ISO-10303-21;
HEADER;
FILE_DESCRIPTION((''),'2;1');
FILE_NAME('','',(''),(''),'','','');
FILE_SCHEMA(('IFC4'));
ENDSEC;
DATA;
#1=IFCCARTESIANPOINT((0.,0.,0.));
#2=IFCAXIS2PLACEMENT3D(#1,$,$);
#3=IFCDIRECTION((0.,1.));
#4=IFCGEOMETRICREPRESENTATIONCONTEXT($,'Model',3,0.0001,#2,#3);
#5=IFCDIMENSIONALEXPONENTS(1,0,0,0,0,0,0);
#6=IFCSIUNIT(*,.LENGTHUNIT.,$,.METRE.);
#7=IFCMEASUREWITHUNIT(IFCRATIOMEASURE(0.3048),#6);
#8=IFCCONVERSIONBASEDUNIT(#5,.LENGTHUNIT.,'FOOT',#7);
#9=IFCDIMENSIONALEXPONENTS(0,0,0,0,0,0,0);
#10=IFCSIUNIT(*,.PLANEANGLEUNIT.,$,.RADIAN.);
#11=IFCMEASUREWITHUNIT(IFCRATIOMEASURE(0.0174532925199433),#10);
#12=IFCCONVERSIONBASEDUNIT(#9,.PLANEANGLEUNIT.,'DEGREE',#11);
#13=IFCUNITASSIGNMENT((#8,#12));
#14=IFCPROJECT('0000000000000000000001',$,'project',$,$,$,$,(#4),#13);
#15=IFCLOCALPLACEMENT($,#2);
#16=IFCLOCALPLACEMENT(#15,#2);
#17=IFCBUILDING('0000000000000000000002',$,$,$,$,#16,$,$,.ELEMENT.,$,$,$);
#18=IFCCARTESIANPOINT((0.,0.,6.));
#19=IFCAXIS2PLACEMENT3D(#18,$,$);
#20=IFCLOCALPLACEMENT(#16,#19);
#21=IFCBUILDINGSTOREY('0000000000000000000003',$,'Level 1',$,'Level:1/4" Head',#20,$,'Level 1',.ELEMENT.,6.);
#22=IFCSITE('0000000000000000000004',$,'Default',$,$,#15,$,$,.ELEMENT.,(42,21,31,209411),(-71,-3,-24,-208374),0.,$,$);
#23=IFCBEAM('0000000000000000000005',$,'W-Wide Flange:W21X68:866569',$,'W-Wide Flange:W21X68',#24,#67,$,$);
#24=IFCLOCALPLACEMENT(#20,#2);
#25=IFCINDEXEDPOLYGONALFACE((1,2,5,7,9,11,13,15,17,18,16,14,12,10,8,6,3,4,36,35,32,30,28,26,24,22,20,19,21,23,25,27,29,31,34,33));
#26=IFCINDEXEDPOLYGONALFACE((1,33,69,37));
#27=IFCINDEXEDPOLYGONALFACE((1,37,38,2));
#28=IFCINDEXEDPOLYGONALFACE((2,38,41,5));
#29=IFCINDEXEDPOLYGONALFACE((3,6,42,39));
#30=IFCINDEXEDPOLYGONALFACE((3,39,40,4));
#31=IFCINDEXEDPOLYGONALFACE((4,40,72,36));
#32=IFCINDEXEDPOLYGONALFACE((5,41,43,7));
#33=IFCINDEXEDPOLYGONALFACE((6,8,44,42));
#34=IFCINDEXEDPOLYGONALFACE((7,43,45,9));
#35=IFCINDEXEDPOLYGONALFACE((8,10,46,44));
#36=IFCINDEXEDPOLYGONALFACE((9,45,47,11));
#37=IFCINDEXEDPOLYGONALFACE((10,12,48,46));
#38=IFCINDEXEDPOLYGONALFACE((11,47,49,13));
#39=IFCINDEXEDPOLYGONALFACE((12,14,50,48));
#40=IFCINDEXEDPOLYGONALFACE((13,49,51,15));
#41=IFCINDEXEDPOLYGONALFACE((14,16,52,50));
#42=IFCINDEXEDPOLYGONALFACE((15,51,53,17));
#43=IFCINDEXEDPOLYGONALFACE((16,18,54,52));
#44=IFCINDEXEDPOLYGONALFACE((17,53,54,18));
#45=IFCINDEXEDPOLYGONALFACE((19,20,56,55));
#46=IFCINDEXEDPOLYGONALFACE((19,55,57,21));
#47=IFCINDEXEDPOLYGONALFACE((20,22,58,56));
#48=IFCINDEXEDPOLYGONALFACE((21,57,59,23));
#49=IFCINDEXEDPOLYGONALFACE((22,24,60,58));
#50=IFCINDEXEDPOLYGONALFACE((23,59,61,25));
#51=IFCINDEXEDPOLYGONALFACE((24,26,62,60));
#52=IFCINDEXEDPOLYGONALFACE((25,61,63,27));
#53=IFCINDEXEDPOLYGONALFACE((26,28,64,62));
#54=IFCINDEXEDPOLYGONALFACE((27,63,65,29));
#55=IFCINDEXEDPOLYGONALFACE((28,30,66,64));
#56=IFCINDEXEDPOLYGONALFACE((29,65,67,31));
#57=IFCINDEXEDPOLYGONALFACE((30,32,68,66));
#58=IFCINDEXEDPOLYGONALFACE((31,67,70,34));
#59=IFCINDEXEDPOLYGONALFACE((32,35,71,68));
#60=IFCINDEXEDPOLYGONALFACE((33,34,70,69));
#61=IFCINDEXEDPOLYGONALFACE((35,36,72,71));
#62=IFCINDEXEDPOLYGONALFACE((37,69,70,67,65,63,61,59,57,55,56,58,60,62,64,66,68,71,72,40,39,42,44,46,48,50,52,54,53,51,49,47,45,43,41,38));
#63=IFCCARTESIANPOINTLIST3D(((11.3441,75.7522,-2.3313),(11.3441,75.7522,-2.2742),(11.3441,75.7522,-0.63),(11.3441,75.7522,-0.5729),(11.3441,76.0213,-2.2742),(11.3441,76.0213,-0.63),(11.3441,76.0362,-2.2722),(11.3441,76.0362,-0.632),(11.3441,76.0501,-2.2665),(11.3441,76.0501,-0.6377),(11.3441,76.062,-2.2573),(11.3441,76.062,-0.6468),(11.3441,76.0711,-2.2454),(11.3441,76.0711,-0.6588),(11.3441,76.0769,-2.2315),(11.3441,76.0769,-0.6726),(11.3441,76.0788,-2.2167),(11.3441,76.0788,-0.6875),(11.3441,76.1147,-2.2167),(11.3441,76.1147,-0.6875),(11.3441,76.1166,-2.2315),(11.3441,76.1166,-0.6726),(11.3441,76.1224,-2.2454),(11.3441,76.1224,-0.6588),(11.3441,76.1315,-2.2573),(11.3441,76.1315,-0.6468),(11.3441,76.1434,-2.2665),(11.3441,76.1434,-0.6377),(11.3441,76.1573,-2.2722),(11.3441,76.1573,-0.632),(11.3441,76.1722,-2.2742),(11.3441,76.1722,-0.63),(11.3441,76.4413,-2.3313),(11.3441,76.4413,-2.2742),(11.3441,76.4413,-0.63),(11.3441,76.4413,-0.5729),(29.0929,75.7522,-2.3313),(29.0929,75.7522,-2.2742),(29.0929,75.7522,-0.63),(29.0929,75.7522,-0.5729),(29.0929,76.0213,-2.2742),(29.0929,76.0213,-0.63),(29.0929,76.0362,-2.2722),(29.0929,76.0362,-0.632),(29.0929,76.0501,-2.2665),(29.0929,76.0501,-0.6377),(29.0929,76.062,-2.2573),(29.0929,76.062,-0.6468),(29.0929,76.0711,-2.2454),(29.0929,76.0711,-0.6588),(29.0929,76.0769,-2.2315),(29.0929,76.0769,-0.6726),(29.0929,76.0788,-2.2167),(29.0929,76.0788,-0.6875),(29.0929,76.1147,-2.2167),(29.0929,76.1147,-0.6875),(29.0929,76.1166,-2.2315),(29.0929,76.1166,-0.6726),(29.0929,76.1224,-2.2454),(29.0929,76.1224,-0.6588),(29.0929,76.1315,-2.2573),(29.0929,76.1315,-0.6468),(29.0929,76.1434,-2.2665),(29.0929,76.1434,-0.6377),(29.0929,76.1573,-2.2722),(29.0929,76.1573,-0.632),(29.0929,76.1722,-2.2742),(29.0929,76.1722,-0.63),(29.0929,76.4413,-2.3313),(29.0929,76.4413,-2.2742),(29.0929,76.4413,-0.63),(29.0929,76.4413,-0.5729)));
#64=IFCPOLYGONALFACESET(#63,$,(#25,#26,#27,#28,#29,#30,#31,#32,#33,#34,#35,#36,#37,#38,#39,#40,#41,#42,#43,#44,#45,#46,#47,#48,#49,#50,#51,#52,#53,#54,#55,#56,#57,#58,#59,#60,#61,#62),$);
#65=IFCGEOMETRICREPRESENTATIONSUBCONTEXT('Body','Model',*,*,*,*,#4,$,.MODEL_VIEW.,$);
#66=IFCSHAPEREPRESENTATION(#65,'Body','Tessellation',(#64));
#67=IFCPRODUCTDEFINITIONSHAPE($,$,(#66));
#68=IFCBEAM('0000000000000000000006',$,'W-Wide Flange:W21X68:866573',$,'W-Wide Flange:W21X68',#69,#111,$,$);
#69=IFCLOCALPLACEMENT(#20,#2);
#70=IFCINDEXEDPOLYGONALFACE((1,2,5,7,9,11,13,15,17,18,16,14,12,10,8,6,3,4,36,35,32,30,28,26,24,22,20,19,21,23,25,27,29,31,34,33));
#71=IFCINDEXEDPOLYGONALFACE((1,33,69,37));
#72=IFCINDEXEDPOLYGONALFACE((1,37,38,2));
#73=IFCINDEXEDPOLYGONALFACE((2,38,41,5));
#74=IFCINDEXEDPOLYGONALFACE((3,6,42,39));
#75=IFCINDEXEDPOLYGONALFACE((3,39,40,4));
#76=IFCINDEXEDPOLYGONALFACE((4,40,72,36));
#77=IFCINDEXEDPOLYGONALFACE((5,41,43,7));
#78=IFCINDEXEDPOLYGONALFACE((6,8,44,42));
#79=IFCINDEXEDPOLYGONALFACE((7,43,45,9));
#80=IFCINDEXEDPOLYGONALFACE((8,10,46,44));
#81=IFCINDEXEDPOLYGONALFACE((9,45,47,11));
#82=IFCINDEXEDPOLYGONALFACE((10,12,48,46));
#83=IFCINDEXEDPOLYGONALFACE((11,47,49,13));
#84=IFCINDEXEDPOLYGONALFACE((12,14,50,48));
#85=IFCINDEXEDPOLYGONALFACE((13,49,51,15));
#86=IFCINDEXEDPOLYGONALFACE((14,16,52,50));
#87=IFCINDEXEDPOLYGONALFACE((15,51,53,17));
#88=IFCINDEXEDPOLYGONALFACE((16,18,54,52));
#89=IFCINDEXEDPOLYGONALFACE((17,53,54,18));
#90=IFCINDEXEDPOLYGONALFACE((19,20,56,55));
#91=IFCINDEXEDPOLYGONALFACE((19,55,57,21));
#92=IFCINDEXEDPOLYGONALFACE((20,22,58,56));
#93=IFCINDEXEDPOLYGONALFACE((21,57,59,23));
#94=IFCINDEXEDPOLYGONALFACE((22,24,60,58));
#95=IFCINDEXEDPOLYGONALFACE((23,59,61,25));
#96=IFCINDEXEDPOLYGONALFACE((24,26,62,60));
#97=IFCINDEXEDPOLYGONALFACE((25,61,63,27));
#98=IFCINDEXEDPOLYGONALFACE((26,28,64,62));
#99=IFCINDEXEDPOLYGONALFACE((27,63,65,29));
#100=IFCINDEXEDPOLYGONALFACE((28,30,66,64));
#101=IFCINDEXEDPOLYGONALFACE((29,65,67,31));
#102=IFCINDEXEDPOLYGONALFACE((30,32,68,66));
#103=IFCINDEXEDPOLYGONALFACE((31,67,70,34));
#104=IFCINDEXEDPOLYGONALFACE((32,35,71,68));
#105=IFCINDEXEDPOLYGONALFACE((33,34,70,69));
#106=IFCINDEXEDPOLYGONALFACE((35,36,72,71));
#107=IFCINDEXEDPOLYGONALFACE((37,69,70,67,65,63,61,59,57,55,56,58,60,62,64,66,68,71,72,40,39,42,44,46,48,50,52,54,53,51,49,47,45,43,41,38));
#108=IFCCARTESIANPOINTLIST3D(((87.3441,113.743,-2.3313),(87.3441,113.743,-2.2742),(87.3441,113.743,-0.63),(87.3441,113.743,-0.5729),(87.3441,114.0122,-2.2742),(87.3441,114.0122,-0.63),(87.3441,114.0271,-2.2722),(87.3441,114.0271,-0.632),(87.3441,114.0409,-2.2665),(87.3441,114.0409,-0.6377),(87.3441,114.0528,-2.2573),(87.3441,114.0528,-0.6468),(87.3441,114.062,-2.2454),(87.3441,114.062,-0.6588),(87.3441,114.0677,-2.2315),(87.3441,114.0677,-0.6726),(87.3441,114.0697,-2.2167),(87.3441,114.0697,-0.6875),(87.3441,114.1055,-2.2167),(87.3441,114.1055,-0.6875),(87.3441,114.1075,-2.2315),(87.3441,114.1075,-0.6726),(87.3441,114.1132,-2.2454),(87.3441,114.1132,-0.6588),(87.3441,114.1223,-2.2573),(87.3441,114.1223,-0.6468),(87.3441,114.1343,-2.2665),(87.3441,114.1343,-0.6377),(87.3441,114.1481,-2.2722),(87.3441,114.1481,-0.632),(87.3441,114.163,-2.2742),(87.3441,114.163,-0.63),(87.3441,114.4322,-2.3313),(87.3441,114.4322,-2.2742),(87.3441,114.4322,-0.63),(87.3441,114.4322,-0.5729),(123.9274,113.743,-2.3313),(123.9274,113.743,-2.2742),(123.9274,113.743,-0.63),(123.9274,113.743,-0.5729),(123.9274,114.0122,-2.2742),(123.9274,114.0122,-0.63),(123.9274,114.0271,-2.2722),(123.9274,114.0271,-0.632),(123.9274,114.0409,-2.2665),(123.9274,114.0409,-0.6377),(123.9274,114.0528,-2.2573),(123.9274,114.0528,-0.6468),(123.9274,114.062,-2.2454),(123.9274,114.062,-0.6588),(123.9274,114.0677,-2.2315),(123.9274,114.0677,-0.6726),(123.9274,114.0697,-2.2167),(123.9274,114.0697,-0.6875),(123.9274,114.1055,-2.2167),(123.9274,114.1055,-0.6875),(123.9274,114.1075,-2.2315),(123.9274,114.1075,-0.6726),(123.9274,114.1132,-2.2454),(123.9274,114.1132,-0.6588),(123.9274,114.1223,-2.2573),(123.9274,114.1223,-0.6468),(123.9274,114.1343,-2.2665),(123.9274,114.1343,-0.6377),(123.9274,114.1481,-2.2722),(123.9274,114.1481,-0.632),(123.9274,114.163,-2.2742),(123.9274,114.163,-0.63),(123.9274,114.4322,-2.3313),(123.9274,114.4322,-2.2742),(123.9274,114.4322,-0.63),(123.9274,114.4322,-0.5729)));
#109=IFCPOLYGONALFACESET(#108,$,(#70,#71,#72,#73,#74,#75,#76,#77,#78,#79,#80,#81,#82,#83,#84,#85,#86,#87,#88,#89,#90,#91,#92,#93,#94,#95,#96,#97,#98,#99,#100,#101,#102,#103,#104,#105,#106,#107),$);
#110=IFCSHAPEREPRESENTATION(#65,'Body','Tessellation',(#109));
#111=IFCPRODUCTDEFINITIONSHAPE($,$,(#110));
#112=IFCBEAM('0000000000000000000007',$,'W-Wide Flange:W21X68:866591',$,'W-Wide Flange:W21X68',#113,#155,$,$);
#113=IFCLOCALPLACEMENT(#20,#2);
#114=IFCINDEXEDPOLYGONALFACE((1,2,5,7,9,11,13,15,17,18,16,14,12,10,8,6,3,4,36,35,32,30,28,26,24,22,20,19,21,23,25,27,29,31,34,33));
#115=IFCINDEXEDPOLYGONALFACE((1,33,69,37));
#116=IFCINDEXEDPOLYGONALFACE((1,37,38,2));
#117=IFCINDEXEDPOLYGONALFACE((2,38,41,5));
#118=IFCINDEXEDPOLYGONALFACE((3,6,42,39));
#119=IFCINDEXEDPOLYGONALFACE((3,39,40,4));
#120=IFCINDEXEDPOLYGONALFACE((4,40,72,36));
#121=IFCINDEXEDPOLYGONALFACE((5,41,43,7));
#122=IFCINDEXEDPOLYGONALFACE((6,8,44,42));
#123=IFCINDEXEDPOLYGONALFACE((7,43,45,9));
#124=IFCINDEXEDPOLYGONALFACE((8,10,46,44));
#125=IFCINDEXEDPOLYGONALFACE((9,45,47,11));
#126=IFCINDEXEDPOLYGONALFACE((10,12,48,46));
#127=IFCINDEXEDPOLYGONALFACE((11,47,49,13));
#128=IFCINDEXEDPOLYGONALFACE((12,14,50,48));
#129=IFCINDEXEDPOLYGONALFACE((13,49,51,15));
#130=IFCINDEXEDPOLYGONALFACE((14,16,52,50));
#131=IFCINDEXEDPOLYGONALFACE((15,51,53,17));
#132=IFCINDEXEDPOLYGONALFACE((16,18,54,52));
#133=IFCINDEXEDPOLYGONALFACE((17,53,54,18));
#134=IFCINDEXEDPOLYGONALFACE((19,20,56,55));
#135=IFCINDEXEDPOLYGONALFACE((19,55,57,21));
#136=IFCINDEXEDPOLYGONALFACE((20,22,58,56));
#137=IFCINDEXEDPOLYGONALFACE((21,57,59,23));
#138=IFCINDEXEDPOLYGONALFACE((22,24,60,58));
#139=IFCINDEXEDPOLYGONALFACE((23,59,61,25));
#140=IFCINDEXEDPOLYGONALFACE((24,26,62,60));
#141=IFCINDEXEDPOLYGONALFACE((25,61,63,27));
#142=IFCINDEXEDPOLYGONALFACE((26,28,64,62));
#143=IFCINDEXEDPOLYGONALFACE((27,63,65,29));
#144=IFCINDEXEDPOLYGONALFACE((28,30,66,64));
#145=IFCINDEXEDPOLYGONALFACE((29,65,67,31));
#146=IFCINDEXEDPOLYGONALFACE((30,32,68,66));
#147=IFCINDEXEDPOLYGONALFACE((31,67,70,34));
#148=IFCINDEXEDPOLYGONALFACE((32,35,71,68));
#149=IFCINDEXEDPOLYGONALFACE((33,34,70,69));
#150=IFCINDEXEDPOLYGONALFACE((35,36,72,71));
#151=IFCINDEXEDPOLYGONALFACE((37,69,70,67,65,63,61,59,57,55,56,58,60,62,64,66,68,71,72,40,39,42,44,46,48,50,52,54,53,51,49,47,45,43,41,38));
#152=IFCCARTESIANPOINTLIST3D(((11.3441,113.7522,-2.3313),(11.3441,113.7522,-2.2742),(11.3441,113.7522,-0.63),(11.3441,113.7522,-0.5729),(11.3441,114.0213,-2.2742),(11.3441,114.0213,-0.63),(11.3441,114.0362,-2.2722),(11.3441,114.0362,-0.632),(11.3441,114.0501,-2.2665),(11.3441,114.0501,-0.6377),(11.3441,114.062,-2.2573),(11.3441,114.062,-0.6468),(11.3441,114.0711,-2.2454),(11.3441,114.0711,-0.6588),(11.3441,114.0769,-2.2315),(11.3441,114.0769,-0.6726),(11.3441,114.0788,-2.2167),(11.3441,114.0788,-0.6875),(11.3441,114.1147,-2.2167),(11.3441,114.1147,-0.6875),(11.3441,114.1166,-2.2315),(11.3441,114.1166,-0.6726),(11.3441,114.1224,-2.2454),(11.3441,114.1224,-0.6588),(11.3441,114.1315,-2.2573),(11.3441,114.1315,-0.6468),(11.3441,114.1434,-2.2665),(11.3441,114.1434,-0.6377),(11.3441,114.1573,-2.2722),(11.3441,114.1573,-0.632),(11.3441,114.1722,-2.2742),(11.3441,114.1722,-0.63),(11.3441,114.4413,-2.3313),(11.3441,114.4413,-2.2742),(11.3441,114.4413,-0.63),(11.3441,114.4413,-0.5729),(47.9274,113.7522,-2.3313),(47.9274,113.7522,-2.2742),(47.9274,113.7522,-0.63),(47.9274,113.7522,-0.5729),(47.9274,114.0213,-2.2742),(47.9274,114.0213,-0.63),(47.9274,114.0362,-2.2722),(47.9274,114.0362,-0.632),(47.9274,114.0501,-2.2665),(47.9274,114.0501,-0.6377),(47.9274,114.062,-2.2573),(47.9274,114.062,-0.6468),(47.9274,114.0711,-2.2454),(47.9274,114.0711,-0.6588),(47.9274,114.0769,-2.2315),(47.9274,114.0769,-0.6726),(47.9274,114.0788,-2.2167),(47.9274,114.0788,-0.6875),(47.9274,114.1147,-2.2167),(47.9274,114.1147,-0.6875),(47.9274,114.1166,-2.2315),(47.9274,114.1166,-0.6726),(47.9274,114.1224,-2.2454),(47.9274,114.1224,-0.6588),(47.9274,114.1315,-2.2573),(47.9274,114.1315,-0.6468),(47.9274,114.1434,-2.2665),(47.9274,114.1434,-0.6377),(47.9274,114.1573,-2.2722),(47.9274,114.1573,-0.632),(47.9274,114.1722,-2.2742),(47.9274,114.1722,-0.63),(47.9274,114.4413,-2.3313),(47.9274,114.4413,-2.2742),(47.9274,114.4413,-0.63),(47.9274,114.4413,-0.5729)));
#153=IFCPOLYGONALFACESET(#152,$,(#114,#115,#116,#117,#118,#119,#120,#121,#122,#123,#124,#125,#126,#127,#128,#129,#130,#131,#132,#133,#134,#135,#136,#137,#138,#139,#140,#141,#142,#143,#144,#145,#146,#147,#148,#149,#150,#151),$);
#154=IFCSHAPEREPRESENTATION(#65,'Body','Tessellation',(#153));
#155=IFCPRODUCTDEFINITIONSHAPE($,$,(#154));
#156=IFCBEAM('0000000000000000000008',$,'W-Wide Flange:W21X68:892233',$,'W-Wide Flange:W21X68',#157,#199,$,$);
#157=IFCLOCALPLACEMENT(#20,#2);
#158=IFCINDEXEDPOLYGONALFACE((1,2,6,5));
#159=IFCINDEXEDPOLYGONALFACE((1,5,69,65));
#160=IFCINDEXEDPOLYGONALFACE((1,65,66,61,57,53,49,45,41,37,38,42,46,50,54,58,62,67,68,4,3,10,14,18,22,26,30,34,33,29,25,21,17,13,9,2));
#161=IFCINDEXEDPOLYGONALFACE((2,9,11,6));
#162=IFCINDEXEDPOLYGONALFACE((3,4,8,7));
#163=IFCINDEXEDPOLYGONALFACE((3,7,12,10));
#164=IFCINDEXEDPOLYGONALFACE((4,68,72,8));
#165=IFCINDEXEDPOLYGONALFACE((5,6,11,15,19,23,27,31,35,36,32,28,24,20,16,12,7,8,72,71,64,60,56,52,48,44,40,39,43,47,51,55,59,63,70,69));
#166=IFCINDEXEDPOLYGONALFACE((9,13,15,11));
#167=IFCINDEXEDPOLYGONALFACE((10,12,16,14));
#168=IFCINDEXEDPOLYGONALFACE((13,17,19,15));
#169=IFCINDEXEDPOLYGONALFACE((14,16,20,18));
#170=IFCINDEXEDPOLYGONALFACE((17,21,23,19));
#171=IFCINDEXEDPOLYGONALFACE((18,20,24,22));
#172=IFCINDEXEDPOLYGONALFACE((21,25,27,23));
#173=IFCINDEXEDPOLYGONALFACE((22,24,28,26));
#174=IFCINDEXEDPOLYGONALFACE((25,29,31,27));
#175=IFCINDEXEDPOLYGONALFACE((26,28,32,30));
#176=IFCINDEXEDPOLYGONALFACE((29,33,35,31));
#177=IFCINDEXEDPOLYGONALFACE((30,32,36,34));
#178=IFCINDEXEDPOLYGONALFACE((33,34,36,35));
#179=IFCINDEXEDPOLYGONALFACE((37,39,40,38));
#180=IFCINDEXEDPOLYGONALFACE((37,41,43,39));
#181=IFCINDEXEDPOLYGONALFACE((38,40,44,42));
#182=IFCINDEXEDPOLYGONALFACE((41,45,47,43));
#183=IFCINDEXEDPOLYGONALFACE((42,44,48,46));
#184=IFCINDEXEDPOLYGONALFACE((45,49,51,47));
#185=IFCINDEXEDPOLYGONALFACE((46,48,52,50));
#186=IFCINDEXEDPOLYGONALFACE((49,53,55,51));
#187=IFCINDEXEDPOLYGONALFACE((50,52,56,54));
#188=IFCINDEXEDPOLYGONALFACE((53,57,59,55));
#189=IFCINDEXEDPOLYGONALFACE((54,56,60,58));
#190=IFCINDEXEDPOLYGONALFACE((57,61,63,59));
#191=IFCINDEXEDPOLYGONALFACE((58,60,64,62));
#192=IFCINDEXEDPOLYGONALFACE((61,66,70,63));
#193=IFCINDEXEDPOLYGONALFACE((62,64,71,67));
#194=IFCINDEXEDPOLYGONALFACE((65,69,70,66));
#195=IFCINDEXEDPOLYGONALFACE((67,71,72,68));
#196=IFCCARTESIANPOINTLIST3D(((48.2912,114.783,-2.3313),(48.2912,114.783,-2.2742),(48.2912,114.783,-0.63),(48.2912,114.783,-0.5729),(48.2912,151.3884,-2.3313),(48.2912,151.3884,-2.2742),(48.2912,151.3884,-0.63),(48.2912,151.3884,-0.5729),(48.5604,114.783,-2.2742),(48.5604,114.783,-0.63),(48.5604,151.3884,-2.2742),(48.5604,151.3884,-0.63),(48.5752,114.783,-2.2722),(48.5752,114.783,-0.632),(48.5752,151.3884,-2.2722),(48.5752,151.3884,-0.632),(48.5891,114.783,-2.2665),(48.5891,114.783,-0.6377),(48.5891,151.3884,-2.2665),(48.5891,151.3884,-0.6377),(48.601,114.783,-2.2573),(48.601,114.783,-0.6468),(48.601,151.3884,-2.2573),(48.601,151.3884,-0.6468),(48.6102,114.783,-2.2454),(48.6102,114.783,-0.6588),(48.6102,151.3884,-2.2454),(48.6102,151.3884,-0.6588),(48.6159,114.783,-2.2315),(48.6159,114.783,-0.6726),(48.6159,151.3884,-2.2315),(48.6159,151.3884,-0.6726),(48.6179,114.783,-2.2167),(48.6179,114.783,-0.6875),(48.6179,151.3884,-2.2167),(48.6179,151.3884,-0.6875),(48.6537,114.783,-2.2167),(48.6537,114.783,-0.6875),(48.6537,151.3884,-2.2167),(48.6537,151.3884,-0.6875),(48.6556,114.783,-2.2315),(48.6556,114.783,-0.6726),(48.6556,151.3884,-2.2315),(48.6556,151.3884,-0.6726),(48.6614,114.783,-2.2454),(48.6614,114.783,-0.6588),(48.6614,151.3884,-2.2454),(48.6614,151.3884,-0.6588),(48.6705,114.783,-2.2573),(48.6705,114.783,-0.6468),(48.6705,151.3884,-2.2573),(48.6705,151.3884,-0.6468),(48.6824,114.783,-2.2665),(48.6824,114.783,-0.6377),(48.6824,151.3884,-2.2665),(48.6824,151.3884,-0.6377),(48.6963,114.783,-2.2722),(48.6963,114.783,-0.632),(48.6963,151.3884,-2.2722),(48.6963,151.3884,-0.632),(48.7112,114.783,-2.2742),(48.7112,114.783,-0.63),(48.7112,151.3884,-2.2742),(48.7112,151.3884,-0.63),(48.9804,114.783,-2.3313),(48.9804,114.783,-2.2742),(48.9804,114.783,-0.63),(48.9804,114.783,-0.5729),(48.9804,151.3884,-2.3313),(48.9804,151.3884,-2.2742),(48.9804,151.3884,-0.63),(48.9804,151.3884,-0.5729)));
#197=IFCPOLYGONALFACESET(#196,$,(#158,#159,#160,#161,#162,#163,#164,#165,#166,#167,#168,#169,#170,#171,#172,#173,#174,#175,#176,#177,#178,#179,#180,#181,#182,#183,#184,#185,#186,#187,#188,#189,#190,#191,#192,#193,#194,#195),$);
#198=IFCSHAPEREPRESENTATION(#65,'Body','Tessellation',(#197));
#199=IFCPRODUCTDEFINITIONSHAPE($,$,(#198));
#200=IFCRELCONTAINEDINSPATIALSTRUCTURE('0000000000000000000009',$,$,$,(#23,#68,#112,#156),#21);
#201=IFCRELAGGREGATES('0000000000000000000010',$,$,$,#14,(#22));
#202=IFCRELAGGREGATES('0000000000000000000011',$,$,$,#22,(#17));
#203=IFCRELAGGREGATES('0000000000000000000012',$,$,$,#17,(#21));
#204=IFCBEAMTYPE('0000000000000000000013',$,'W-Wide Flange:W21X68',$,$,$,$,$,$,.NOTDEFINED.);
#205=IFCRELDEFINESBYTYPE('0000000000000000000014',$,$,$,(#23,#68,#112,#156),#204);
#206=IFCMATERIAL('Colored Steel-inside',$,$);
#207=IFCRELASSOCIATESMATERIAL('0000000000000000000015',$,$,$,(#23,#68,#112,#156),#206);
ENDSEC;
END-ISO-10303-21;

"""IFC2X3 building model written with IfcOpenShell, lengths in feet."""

from ifc_helpers import new_model, entity, si_unit, converted_unit, direction, frame, frame_2d, origin, place, context, subcontext, project, spatial, i_section, extrude, material, type_object, element, save


model = new_model("IFC2X3")

# Units and contexts
model_context = context("Model", 3, precision=0.0001, world=origin(), true_north=direction((0.0, 1.0)))
body_context = subcontext(model_context, "Body", "Model", "MODEL_VIEW")
ifc_project = project(units=[converted_unit("LENGTHUNIT", "FOOT", entity("IfcRatioMeasure", 0.3048), si_unit("LENGTHUNIT", "METRE"), dimensions=[1, 0, 0, 0, 0, 0, 0]), converted_unit("PLANEANGLEUNIT", "DEGREE", entity("IfcRatioMeasure", 0.0174532925199433), si_unit("PLANEANGLEUNIT", "RADIAN"), dimensions=[0, 0, 0, 0, 0, 0, 0])], contexts=[model_context])

# Site, building, storey
site_placement = place(None, origin())
site = spatial("IfcSite", under=ifc_project, at=site_placement, Name="Default", CompositionType="ELEMENT", RefLatitude=(42, 21, 31, 209411), RefLongitude=(-71, -3, -24, -208374), RefElevation=0.0)
building_placement = place(site_placement, origin())
building = spatial("IfcBuilding", under=site, at=building_placement, CompositionType="ELEMENT")
storey_placement = place(building_placement, frame((0.0, 0.0, 6.0)))
storey = spatial("IfcBuildingStorey", under=building, at=storey_placement, Name="Level 1", ObjectType="Level:1/4\" Head", LongName="Level 1", CompositionType="ELEMENT", Elevation=6.0)

# Shared definitions
ifc_material_1 = material(Name="Colored Steel-inside")

# Beams
beam_type_1 = type_object("IfcBeamType", Name="W-Wide Flange:W21X68", PredefinedType="NOTDEFINED")
beam_1_placement = place(storey_placement, frame((29.6345, 76.0968, 0.0), z_axis=(0.0, 0.0, 1.0), x_axis=(-1.0, 0.0, 0.0)))
element("IfcBeam", 1, at=beam_1_placement, inside=storey, type_object=beam_type_1, material=ifc_material_1, Name="W-Wide Flange:W21X68:866569", ObjectType="W-Wide Flange:W21X68", context=body_context, shape_type="SweptSolid", body=[
    extrude(i_section(OverallWidth=0.6892, OverallDepth=1.7583, WebThickness=0.0358, FlangeThickness=0.0571, FilletRadius=0.0575, at=frame_2d((0.0, 0.0), x_axis=(0.0, 1.0))), frame((0.5417, 0.0, -1.4521), z_axis=(1.0, 0.0, 0.0), x_axis=(0.0, 0.0, -1.0)), (0.0, 0.0, 1.0), 17.7487),
])
beam_2_placement = place(storey_placement, frame((124.6358, 114.0876, 0.0), z_axis=(0.0, 0.0, 1.0), x_axis=(-1.0, 0.0, 0.0)))
element("IfcBeam", 2, at=beam_2_placement, inside=storey, type_object=beam_type_1, material=ifc_material_1, Name="W-Wide Flange:W21X68:866573", ObjectType="W-Wide Flange:W21X68", context=body_context, shape_type="SweptSolid", body=[
    extrude(i_section(OverallWidth=0.6892, OverallDepth=1.7583, WebThickness=0.0358, FlangeThickness=0.0571, FilletRadius=0.0575, at=frame_2d((0.0, 0.0), x_axis=(0.0, 1.0))), frame((0.7083, 0.0, -1.4521), z_axis=(1.0, 0.0, 0.0), x_axis=(0.0, 0.0, -1.0)), (0.0, 0.0, 1.0), 36.5833),
])
beam_3_placement = place(storey_placement, frame((10.6358, 114.0968, 0.0)))
element("IfcBeam", 3, at=beam_3_placement, inside=storey, type_object=beam_type_1, material=ifc_material_1, Name="W-Wide Flange:W21X68:866591", ObjectType="W-Wide Flange:W21X68", context=body_context, shape_type="SweptSolid", body=[
    extrude(i_section(OverallWidth=0.6892, OverallDepth=1.7583, WebThickness=0.0358, FlangeThickness=0.0571, FilletRadius=0.0575, at=frame_2d((0.0, 0.0), x_axis=(0.0, 1.0))), frame((0.7083, 0.0, -1.4521), z_axis=(1.0, 0.0, 0.0), x_axis=(0.0, 0.0, -1.0)), (0.0, 0.0, 1.0), 36.5833),
])
beam_4_placement = place(storey_placement, frame((48.6358, 152.0968, 0.0), z_axis=(0.0, 0.0, 1.0), x_axis=(0.0, -1.0, 0.0)))
element("IfcBeam", 4, at=beam_4_placement, inside=storey, type_object=beam_type_1, material=ifc_material_1, Name="W-Wide Flange:W21X68:892233", ObjectType="W-Wide Flange:W21X68", context=body_context, shape_type="SweptSolid", body=[
    extrude(i_section(OverallWidth=0.6892, OverallDepth=1.7583, WebThickness=0.0358, FlangeThickness=0.0571, FilletRadius=0.0575, at=frame_2d((0.0, 0.0), x_axis=(0.0, 1.0))), frame((0.7083, 0.0, -1.4521), z_axis=(1.0, 0.0, 0.0), x_axis=(0.0, 0.0, -1.0)), (0.0, 0.0, 1.0), 36.6054),
])

save(model, "model.ifc")
